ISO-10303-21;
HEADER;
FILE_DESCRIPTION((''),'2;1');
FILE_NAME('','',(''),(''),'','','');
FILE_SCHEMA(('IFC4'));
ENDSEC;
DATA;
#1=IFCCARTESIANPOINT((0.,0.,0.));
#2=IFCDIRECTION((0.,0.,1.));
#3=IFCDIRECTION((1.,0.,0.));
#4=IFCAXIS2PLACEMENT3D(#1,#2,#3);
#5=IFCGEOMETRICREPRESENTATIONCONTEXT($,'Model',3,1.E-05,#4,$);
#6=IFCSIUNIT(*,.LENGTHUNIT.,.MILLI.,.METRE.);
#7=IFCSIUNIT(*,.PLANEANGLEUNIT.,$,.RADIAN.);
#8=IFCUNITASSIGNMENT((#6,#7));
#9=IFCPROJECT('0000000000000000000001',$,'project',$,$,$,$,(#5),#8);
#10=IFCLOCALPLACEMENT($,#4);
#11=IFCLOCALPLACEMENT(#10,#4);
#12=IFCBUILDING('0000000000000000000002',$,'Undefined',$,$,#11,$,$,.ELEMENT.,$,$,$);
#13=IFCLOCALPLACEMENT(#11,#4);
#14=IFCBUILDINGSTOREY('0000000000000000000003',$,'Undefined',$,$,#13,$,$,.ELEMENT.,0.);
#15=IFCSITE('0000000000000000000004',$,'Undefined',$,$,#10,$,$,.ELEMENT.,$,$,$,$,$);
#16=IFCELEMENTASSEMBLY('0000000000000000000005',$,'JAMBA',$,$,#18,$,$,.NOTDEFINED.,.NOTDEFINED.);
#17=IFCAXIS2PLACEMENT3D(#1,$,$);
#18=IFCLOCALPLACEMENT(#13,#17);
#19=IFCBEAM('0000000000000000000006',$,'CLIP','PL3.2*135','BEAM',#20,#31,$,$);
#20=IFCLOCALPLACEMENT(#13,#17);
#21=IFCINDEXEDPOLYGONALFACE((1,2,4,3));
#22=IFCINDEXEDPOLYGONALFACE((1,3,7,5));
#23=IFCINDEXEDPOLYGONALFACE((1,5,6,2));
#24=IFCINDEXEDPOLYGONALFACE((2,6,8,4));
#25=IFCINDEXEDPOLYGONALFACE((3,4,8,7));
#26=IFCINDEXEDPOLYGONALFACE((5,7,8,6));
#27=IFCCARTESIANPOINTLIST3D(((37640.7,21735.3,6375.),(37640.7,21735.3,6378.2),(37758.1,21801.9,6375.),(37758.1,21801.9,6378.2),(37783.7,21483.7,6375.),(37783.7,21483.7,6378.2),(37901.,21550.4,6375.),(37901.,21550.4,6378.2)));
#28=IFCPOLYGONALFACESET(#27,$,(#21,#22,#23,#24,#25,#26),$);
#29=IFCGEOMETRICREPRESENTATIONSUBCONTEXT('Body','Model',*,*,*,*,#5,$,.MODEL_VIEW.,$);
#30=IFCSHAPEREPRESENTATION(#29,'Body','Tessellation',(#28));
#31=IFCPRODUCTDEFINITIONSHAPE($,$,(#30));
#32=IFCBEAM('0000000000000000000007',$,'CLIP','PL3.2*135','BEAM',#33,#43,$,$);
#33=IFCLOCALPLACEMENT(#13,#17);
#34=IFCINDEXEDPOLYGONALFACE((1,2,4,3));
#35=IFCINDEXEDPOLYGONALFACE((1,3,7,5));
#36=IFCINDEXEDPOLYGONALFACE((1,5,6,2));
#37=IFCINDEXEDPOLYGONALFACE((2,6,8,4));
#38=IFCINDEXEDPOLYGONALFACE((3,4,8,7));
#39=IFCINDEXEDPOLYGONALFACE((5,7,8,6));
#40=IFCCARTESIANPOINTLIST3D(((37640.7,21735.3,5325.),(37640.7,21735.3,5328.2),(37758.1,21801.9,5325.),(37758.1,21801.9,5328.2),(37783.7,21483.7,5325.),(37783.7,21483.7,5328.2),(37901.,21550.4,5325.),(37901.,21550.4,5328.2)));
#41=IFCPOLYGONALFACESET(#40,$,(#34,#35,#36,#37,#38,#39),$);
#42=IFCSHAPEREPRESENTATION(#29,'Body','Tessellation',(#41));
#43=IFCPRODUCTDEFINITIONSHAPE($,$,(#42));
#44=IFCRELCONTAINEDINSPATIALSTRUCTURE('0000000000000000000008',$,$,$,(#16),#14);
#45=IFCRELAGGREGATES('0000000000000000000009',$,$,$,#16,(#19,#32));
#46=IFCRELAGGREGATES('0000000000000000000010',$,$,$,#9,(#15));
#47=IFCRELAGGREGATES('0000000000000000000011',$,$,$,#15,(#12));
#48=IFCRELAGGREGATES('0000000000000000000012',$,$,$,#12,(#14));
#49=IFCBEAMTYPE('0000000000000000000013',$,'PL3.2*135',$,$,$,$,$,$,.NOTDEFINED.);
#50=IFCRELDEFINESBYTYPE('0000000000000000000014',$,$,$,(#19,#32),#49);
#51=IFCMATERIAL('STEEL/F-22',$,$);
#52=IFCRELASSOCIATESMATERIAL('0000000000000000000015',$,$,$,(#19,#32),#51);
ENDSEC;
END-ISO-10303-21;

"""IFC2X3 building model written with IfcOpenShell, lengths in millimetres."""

from ifc_helpers import new_model, si_unit, frame, origin_with_axes, origin_2d_with_axis, place, context, subcontext, project, spatial, rectangle, extrude, material, type_object, element, aggregate, save


model = new_model("IFC2X3")

# Units and contexts
model_context = context("Model", 3, precision=1e-05, world=origin_with_axes())
body_context = subcontext(model_context, "Body", "Model", "MODEL_VIEW")
ifc_project = project(units=[si_unit("LENGTHUNIT", "METRE", prefix="MILLI"), si_unit("PLANEANGLEUNIT", "RADIAN")], contexts=[model_context])

# Site, building, storey
site_placement = place(None, origin_with_axes())
site = spatial("IfcSite", under=ifc_project, at=site_placement, Name="Undefined", CompositionType="ELEMENT")
building_placement = place(site_placement, origin_with_axes())
building = spatial("IfcBuilding", under=site, at=building_placement, Name="Undefined", CompositionType="ELEMENT")
storey_placement = place(building_placement, origin_with_axes())
storey = spatial("IfcBuildingStorey", under=building, at=storey_placement, Name="Undefined", CompositionType="ELEMENT", Elevation=0.0)

# Element assembly, beams
assembly_1_placement = place(storey_placement, origin_with_axes())
assembly_1 = element("IfcElementAssembly", 1, at=assembly_1_placement, inside=storey, Name="JAMBA", AssemblyPlace="NOTDEFINED", PredefinedType="NOTDEFINED")
ifc_material_1 = material(Name="STEEL/F-22")
beam_type_1 = type_object("IfcBeamType", Name="PL3.2*135", PredefinedType="NOTDEFINED")
beam_1_placement = place(assembly_1_placement, frame((37842.3, 21517.0, 6376.6), z_axis=(-0.869495, -0.493942, 0.0), x_axis=(-0.493942, 0.869495, 0.0)))
beam_1 = element("IfcBeam", 2, at=beam_1_placement, type_object=beam_type_1, material=ifc_material_1, Name="CLIP", Description="PL3.2*135", ObjectType="BEAM", context=body_context, shape_type="SweptSolid", body=[
    extrude(rectangle(XDim=3.2, YDim=135.0, at=origin_2d_with_axis()), frame((289.3, 0.0, 0.0), z_axis=(-1.0, 0.0, 0.0), x_axis=(0.0, -1.0, 0.0)), (0.0, 0.0, 1.0), 289.3),
])
beam_2_placement = place(assembly_1_placement, frame((37842.3, 21517.0, 5326.6), z_axis=(-0.869495, -0.493942, 0.0), x_axis=(-0.493942, 0.869495, 0.0)))
beam_2 = element("IfcBeam", 3, at=beam_2_placement, type_object=beam_type_1, material=ifc_material_1, Name="CLIP", Description="PL3.2*135", ObjectType="BEAM", context=body_context, shape_type="SweptSolid", body=[
    extrude(rectangle(XDim=3.2, YDim=135.0, at=origin_2d_with_axis()), frame((289.3, 0.0, 0.0), z_axis=(-1.0, 0.0, 0.0), x_axis=(0.0, -1.0, 0.0)), (0.0, 0.0, 1.0), 289.3),
])
aggregate(assembly_1, [beam_1, beam_2])

save(model, "model.ifc")
